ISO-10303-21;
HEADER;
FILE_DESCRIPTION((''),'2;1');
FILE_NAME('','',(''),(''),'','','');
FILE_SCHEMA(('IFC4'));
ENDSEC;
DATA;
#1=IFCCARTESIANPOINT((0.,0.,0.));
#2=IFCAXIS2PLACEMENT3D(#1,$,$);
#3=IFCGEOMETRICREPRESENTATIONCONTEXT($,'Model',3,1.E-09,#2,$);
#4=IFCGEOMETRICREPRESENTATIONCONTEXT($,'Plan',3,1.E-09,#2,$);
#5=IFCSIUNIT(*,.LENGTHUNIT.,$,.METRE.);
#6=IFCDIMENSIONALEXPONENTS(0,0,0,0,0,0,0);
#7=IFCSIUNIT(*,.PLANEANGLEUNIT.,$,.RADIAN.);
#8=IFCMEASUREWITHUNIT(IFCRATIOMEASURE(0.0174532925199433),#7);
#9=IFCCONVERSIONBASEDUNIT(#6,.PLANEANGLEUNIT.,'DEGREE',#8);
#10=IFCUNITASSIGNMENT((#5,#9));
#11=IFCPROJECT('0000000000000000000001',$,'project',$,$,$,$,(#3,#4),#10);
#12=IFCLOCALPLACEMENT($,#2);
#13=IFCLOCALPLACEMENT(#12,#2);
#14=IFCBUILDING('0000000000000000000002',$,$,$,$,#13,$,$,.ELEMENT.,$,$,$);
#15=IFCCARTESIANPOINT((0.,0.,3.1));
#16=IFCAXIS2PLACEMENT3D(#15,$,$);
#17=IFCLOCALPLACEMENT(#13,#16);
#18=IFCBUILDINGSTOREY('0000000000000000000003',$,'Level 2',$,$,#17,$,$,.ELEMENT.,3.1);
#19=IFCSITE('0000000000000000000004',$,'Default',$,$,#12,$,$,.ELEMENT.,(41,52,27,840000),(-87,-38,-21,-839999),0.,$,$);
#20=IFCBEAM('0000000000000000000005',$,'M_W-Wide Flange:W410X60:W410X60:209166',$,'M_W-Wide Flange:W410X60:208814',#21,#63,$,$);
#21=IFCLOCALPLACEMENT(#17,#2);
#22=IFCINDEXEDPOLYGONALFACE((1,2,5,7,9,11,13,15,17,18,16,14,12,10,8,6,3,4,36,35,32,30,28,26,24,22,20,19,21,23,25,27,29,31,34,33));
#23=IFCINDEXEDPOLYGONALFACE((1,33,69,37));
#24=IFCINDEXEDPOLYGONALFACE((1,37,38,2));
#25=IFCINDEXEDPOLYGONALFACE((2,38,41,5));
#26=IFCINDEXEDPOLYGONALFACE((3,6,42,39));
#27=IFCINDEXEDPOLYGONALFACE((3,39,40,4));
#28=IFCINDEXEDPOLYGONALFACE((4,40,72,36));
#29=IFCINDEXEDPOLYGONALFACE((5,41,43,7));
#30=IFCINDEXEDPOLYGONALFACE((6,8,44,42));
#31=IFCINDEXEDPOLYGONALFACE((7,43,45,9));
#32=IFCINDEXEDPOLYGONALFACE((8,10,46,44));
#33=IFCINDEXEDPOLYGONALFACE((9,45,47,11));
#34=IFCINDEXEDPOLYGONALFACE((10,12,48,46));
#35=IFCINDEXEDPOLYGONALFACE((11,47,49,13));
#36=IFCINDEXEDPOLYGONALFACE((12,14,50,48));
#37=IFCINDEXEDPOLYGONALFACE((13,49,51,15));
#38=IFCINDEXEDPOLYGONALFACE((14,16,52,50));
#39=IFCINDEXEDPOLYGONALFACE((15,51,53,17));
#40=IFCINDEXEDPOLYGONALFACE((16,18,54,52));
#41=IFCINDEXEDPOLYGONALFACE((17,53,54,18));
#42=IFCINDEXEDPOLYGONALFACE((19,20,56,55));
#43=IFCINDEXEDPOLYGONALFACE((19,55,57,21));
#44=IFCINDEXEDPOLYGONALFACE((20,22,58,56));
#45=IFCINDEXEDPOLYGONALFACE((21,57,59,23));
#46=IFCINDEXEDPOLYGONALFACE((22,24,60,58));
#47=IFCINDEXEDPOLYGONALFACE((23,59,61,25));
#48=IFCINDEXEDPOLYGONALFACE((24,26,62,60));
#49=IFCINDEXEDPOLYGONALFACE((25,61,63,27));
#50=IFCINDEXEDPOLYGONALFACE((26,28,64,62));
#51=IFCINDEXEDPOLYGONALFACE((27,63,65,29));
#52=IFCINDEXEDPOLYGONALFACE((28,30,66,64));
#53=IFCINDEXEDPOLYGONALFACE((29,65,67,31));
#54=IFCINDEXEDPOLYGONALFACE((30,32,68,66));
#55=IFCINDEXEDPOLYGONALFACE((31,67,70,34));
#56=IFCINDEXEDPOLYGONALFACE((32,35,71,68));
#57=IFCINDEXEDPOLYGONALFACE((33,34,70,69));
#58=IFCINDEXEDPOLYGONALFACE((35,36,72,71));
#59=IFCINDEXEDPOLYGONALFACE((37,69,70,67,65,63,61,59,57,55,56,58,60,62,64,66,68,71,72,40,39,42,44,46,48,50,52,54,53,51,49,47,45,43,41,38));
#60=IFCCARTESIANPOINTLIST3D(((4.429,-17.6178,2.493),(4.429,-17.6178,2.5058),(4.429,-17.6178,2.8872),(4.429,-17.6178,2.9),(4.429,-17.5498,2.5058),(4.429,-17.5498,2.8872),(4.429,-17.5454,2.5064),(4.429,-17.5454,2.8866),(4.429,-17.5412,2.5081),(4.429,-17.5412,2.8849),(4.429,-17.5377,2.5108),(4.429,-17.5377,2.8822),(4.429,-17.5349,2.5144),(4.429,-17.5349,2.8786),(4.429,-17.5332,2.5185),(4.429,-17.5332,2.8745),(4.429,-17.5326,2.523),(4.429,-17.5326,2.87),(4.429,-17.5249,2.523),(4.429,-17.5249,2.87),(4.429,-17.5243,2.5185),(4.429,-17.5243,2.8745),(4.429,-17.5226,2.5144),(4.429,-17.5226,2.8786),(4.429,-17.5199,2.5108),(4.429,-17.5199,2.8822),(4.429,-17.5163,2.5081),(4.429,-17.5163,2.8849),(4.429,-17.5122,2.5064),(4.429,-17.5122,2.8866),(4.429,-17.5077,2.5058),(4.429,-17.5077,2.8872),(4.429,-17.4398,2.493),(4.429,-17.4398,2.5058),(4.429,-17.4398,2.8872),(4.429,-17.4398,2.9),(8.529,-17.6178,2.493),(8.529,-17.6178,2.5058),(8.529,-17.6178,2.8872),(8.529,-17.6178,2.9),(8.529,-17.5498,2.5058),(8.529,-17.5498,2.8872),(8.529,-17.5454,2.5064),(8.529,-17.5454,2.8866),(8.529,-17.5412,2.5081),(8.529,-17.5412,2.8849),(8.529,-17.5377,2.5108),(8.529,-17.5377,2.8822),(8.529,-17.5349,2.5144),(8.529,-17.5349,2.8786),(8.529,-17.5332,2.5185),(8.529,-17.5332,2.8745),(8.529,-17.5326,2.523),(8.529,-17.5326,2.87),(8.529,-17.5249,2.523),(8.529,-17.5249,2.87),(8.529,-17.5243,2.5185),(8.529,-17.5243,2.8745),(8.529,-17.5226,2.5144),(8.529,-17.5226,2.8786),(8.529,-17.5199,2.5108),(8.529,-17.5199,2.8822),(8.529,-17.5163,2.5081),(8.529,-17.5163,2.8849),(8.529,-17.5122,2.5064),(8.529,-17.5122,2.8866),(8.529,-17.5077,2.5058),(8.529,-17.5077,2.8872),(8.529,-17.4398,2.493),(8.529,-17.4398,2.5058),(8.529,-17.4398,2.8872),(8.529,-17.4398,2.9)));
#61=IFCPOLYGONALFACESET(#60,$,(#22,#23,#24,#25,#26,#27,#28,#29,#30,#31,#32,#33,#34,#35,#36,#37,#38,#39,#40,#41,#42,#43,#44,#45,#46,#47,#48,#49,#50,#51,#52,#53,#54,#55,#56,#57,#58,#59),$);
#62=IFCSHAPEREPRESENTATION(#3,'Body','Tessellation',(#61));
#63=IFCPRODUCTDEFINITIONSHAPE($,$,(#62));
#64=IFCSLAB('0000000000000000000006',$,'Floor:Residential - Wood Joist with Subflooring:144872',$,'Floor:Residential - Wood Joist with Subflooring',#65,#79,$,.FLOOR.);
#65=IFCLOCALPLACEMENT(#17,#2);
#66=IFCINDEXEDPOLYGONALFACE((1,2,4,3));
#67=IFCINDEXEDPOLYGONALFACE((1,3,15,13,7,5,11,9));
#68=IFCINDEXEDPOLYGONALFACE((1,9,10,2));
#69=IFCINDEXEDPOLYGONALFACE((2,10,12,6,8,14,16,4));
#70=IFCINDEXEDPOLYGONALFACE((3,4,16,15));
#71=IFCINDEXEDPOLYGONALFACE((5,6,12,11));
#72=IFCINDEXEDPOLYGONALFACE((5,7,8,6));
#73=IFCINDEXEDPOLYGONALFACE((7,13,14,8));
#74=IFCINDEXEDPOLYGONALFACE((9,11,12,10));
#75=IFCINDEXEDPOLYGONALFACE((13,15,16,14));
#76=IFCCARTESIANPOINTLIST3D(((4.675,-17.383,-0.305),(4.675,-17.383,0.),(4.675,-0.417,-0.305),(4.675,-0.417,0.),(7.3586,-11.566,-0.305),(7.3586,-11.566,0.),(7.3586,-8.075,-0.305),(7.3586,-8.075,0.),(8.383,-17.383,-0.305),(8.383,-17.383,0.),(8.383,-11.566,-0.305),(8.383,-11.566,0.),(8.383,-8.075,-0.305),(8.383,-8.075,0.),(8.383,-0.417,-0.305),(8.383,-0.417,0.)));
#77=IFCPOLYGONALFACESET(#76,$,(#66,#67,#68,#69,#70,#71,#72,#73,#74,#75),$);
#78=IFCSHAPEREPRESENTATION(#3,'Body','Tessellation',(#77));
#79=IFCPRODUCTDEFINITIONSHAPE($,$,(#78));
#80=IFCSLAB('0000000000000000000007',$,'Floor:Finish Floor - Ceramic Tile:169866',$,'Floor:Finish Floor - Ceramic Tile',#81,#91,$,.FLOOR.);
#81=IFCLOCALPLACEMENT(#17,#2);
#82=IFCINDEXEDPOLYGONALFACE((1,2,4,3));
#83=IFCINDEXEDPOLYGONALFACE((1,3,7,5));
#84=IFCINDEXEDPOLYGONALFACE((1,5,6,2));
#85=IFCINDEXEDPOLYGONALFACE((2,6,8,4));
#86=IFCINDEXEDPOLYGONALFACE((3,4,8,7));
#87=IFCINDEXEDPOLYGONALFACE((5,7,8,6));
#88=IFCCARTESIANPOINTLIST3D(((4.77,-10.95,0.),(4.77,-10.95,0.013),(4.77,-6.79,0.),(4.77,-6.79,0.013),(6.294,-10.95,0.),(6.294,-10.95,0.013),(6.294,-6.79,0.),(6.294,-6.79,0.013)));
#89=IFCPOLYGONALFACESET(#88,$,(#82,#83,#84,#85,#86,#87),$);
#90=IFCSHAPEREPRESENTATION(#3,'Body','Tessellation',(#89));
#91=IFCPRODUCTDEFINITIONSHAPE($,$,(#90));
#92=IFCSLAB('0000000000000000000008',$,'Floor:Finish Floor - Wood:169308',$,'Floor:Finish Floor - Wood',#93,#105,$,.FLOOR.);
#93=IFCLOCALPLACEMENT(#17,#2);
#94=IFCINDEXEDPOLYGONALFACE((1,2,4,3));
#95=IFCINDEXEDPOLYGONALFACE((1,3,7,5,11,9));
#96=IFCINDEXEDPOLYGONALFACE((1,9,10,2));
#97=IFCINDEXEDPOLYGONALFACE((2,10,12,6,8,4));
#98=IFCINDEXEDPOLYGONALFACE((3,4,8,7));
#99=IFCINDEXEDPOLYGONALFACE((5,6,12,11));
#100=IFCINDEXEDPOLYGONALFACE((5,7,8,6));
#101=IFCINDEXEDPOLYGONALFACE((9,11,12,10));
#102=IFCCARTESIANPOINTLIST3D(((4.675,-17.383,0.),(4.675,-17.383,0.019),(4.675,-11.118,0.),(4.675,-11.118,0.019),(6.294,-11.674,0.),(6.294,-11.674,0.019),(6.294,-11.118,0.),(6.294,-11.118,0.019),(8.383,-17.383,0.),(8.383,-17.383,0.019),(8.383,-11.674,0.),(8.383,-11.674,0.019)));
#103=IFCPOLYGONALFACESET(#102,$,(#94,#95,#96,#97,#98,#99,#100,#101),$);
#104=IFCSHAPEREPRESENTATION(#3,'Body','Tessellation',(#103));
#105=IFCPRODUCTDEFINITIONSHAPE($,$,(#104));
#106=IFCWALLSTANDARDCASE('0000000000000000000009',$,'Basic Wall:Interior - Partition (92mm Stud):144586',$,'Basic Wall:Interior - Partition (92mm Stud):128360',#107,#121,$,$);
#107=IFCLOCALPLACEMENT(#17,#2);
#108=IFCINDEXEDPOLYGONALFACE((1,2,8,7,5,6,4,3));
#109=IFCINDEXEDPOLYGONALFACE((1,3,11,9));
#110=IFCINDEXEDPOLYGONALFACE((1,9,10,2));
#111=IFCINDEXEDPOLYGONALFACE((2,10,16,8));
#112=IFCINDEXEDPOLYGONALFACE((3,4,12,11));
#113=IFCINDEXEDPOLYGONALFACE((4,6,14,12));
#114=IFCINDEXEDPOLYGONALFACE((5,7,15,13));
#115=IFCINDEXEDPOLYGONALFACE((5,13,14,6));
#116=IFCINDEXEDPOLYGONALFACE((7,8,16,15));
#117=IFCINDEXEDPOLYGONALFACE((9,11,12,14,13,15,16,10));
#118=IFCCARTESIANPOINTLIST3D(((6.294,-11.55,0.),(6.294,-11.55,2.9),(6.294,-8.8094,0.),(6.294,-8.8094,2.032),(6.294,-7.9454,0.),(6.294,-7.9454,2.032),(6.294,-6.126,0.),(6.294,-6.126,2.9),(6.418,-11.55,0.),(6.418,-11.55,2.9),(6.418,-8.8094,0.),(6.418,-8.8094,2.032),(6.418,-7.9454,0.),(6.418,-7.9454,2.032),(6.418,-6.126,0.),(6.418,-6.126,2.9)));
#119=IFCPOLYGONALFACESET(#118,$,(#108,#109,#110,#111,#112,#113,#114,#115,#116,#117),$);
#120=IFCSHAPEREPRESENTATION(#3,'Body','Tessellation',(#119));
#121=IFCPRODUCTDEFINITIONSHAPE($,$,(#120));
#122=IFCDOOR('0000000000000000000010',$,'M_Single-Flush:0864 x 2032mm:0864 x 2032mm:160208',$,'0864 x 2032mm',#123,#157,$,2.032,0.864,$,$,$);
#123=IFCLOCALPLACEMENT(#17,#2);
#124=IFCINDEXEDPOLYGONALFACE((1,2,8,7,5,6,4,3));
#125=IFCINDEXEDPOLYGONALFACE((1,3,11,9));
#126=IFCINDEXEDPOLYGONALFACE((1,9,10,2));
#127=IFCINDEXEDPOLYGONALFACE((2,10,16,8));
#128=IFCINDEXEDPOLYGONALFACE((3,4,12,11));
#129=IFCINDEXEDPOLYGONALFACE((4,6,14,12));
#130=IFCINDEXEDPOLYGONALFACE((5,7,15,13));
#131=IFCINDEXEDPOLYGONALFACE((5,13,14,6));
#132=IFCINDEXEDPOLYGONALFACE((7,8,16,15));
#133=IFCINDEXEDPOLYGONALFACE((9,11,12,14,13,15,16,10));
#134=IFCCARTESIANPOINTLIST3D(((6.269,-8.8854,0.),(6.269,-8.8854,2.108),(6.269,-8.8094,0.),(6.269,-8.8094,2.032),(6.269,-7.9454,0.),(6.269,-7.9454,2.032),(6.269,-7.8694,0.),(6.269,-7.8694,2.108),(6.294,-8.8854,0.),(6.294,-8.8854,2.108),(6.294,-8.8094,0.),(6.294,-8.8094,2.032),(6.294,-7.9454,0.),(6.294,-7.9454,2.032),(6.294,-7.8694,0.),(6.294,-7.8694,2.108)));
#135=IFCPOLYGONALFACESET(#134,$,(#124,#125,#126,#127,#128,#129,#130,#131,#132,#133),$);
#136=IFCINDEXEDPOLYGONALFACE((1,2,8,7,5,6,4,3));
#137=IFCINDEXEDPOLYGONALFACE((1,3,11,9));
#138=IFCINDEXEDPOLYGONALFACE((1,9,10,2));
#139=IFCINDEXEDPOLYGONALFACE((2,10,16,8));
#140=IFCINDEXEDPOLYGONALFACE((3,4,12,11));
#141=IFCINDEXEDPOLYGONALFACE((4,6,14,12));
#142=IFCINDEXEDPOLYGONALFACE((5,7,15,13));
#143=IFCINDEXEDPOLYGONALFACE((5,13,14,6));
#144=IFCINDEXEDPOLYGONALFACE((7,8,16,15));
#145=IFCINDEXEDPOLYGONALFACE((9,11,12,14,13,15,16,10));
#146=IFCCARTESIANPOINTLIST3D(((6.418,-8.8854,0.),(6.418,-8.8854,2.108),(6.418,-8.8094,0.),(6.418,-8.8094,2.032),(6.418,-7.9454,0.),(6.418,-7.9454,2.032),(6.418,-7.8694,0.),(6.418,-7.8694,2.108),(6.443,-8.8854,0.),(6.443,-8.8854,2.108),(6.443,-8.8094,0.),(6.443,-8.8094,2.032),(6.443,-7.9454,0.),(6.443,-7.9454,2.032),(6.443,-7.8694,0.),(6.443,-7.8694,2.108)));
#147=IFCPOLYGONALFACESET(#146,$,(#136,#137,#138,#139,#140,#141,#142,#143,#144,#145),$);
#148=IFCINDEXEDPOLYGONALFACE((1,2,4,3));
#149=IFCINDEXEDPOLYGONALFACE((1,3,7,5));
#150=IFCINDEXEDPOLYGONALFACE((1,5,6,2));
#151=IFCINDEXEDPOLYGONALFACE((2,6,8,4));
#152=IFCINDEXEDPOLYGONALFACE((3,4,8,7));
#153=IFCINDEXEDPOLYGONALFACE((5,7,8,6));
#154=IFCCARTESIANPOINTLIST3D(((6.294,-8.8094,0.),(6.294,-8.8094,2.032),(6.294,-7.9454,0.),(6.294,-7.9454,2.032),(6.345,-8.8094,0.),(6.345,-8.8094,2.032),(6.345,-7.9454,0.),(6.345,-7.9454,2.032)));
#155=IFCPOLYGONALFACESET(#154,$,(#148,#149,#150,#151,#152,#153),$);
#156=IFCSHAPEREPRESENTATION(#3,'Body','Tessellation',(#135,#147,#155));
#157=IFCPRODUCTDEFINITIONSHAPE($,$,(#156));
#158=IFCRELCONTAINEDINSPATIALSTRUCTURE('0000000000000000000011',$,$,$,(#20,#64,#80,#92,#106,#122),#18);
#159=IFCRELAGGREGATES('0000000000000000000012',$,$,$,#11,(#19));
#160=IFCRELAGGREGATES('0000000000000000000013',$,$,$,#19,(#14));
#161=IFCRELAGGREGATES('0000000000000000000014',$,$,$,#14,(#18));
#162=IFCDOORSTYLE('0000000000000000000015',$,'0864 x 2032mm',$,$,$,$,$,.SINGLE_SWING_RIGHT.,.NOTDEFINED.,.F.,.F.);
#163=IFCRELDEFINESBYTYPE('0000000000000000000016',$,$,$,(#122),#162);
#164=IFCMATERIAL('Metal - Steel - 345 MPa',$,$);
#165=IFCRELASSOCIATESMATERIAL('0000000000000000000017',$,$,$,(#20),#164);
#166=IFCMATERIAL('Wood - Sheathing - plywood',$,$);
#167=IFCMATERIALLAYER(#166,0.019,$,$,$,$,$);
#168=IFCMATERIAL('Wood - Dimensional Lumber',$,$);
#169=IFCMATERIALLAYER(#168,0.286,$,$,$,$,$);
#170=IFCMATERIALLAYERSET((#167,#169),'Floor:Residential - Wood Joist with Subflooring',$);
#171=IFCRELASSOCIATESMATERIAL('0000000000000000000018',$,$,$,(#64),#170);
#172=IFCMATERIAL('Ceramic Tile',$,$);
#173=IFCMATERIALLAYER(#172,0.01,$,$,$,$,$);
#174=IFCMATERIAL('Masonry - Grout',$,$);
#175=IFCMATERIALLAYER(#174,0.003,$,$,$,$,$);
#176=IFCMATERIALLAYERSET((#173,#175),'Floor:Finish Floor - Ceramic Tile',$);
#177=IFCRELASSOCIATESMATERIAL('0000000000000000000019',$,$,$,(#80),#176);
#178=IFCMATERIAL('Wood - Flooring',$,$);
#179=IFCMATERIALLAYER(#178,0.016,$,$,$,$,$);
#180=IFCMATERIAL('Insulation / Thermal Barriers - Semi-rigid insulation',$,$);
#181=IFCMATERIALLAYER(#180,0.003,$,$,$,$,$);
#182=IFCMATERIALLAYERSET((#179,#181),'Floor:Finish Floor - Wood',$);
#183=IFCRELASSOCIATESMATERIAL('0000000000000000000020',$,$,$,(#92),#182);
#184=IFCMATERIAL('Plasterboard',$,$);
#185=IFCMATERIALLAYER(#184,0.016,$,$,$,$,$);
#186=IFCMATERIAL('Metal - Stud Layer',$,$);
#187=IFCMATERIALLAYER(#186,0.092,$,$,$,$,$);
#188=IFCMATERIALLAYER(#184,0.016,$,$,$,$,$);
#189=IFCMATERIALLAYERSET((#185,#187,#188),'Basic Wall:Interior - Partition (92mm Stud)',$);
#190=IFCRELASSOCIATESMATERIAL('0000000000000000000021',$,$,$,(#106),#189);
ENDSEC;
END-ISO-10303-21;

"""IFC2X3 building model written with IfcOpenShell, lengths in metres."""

from ifc_helpers import new_model, entity, si_unit, converted_unit, frame, frame_2d, origin, origin_2d_with_axis, place, context, project, spatial, polyline, circle_curve, parameter, trimmed, segment, composite_curve, rectangle, outline, extrude, source, transform, mapped, material, layer, layer_set, layer_usage, type_object, type_shapes, element, fill, save


model = new_model("IFC2X3")

# Units and contexts
model_context = context("Model", 3, precision=1e-09, world=origin())
plan_context = context("Plan", 3, precision=1e-09, world=origin())
ifc_project = project(units=[si_unit("LENGTHUNIT", "METRE"), converted_unit("PLANEANGLEUNIT", "DEGREE", entity("IfcRatioMeasure", 0.0174532925199433), si_unit("PLANEANGLEUNIT", "RADIAN"), dimensions=[0, 0, 0, 0, 0, 0, 0])], contexts=[model_context, plan_context])

# Site, building, storey
site_placement = place(None, origin())
site = spatial("IfcSite", under=ifc_project, at=site_placement, Name="Default", CompositionType="ELEMENT", RefLatitude=(41, 52, 27, 840000), RefLongitude=(-87, -38, -21, -839999), RefElevation=0.0)
building_placement = place(site_placement, origin())
building = spatial("IfcBuilding", under=site, at=building_placement, CompositionType="ELEMENT")
storey_placement = place(building_placement, frame((0.0, 0.0, 3.1)))
storey = spatial("IfcBuildingStorey", under=building, at=storey_placement, Name="Level 2", CompositionType="ELEMENT", Elevation=3.1)

# Beam
ifc_material_1 = material(Name="Metal - Steel - 345 MPa")
beam_placement = place(storey_placement, frame((4.429, -17.5288, 2.9), z_axis=(0.0, 0.0, 1.0), x_axis=(0.0, -1.0, 0.0)))
element("IfcBeam", 1, at=beam_placement, inside=storey, material=ifc_material_1, Name="M_W-Wide Flange:W410X60:W410X60:209166", ObjectType="M_W-Wide Flange:W410X60:208814", context=model_context, shape_type="SweptSolid", body=[
    extrude(outline(composite_curve([segment(polyline([(-0.089, -0.1907), (-0.089, -0.2035)]), True, "CONTINUOUS"), segment(polyline([(-0.089, -0.2035), (0.089, -0.2035)]), True, "CONTINUOUS"), segment(polyline([(0.089, -0.2035), (0.089, -0.1907)]), True, "CONTINUOUS"), segment(polyline([(0.089, -0.1907), (0.021, -0.1907)]), True, "CONTINUOUS"), segment(trimmed(circle_curve(frame_2d((0.021, -0.1735), x_axis=(0.0, -1.0)), 0.0172), [parameter(270.0)], [parameter(360.0)], True, "PARAMETER"), False, "CONTINUOUS"), segment(polyline([(0.0038, -0.1735), (0.0038, 0.1735)]), True, "CONTINUOUS"), segment(trimmed(circle_curve(frame_2d((0.021, 0.1735), x_axis=(-1.0, 0.0)), 0.0172), [parameter(270.0)], [parameter(360.0)], True, "PARAMETER"), False, "CONTINUOUS"), segment(polyline([(0.021, 0.1907), (0.089, 0.1907)]), True, "CONTINUOUS"), segment(polyline([(0.089, 0.1907), (0.089, 0.2035)]), True, "CONTINUOUS"), segment(polyline([(0.089, 0.2035), (-0.089, 0.2035)]), True, "CONTINUOUS"), segment(polyline([(-0.089, 0.2035), (-0.089, 0.1907)]), True, "CONTINUOUS"), segment(polyline([(-0.089, 0.1907), (-0.0211, 0.1907)]), True, "CONTINUOUS"), segment(trimmed(circle_curve(frame_2d((-0.0211, 0.1735), x_axis=(0.0, 1.0)), 0.0172), [parameter(270.0)], [parameter(0.0)], True, "PARAMETER"), False, "CONTINUOUS"), segment(polyline([(-0.0039, 0.1735), (-0.0039, -0.1735)]), True, "CONTINUOUS"), segment(trimmed(circle_curve(frame_2d((-0.0211, -0.1735), x_axis=(1.0, 0.0)), 0.0172), [parameter(270.0)], [parameter(0.0)], True, "PARAMETER"), False, "CONTINUOUS"), segment(polyline([(-0.0211, -0.1907), (-0.089, -0.1907)]), True, "CONTINUOUS")], self_intersect=False)), frame((0.0, 0.0, -0.2035), z_axis=(0.0, -1.0, 0.0), x_axis=(1.0, 0.0, 0.0)), (0.0, 0.0, -1.0), 4.1),
])

# Slabs
ifc_material_2 = material(Name="Wood - Sheathing - plywood")
ifc_layer_1 = layer(ifc_material_2, 0.019)
ifc_material_3 = material(Name="Wood - Dimensional Lumber")
ifc_layer_2 = layer(ifc_material_3, 0.286)
ifc_layer_set_1 = layer_set([ifc_layer_1, ifc_layer_2], Name="Floor:Residential - Wood Joist with Subflooring")
ifc_layer_usage_1 = layer_usage(ifc_layer_set_1, "AXIS3", "POSITIVE", 0.0)
slab_1_placement = place(storey_placement, frame((4.675, -17.383, -0.305)))
element("IfcSlab", 2, at=slab_1_placement, inside=storey, material=ifc_layer_usage_1, Name="Floor:Residential - Wood Joist with Subflooring:144872", ObjectType="Floor:Residential - Wood Joist with Subflooring", PredefinedType="FLOOR", context=model_context, shape_type="SweptSolid", body=[
    extrude(outline(polyline([(-1.854, 8.483), (-1.854, 0.825), (-0.8296, 0.825), (-0.8296, -2.666), (-1.854, -2.666), (-1.854, -8.483), (1.854, -8.483), (1.854, 8.483), (-1.854, 8.483)])), frame((1.854, 8.483, 0.305), z_axis=(0.0, 0.0, -1.0), x_axis=(-1.0, 0.0, 0.0)), (0.0, 0.0, 1.0), 0.305),
])
ifc_material_4 = material(Name="Ceramic Tile")
ifc_layer_3 = layer(ifc_material_4, 0.01)
ifc_material_5 = material(Name="Masonry - Grout")
ifc_layer_4 = layer(ifc_material_5, 0.003)
ifc_layer_set_2 = layer_set([ifc_layer_3, ifc_layer_4], Name="Floor:Finish Floor - Ceramic Tile")
ifc_layer_usage_2 = layer_usage(ifc_layer_set_2, "AXIS3", "POSITIVE", 0.0)
slab_2_placement = place(storey_placement, frame((4.77, -10.95, 0.0)))
element("IfcSlab", 3, at=slab_2_placement, inside=storey, material=ifc_layer_usage_2, Name="Floor:Finish Floor - Ceramic Tile:169866", ObjectType="Floor:Finish Floor - Ceramic Tile", PredefinedType="FLOOR", context=model_context, shape_type="SweptSolid", body=[
    extrude(rectangle(XDim=4.16, YDim=1.524, at=frame_2d((0.0, 0.0), x_axis=(0.0, -1.0))), frame((0.762, 2.08, 0.013), z_axis=(0.0, 0.0, -1.0), x_axis=(-1.0, 0.0, 0.0)), (0.0, 0.0, 1.0), 0.013),
])
ifc_material_6 = material(Name="Wood - Flooring")
ifc_layer_5 = layer(ifc_material_6, 0.016)
ifc_material_7 = material(Name="Insulation / Thermal Barriers - Semi-rigid insulation")
ifc_layer_6 = layer(ifc_material_7, 0.003)
ifc_layer_set_3 = layer_set([ifc_layer_5, ifc_layer_6], Name="Floor:Finish Floor - Wood")
ifc_layer_usage_3 = layer_usage(ifc_layer_set_3, "AXIS3", "POSITIVE", 0.0)
slab_3_placement = place(storey_placement, frame((4.675, -17.383, 0.0)))
element("IfcSlab", 4, at=slab_3_placement, inside=storey, material=ifc_layer_usage_3, Name="Floor:Finish Floor - Wood:169308", ObjectType="Floor:Finish Floor - Wood", PredefinedType="FLOOR", context=model_context, shape_type="SweptSolid", body=[
    extrude(outline(polyline([(-1.854, 2.5765), (-1.854, -3.1325), (1.854, -3.1325), (1.854, 3.1325), (0.235, 3.1325), (0.235, 2.5765), (-1.854, 2.5765)])), frame((1.854, 3.1325, 0.019), z_axis=(0.0, 0.0, -1.0), x_axis=(-1.0, 0.0, 0.0)), (0.0, 0.0, 1.0), 0.019),
])

# Wall, opening, door
ifc_material_8 = material(Name="Plasterboard")
ifc_layer_7 = layer(ifc_material_8, 0.016)
ifc_material_9 = material(Name="Metal - Stud Layer")
ifc_layer_8 = layer(ifc_material_9, 0.092)
ifc_layer_9 = layer(ifc_material_8, 0.016)
ifc_layer_set_4 = layer_set([ifc_layer_7, ifc_layer_8, ifc_layer_9], Name="Basic Wall:Interior - Partition (92mm Stud)")
ifc_layer_usage_4 = layer_usage(ifc_layer_set_4, "AXIS2", "NEGATIVE", 0.062)
wall_1_placement = place(storey_placement, frame((6.356, -11.55, 0.0), z_axis=(0.0, 0.0, 1.0), x_axis=(0.0, 1.0, 0.0)))
wall_1 = element("IfcWallStandardCase", 5, at=wall_1_placement, inside=storey, material=ifc_layer_usage_4, Name="Basic Wall:Interior - Partition (92mm Stud):144586", ObjectType="Basic Wall:Interior - Partition (92mm Stud):128360", context=model_context, shape_type="SweptSolid", body=[
    extrude(rectangle(XDim=5.424, YDim=0.124, at=frame_2d((2.712, 0.0), x_axis=(-1.0, 0.0))), origin(), (0.0, 0.0, 1.0), 2.9),
])
opening_1_placement = place(wall_1_placement, frame((2.7406, -0.062, 0.0)))
opening_1 = element("IfcOpeningElement", 6, at=opening_1_placement, cuts=wall_1, ObjectType="Opening", context=model_context, shape_type="SweptSolid", body=[
    extrude(rectangle(XDim=0.864, YDim=2.032, at=frame_2d((1.016, 0.432), x_axis=(0.0, 1.0))), frame((0.0, 0.0, 0.0), z_axis=(0.0, 1.0, 0.0), x_axis=(0.0, 0.0, 1.0)), (0.0, 0.0, 1.0), 0.124),
])
door_style = type_object("IfcDoorStyle", Name="0864 x 2032mm", ConstructionType="NOTDEFINED", OperationType="SINGLE_SWING_RIGHT", ParameterTakesPrecedence=False, Sizeable=False)
shared_shape_1 = source(origin(), model_context, "Body", "SweptSolid", [
    extrude(outline(polyline([(-0.508, -1.073), (0.508, -1.073), (0.508, 1.035), (0.432, 1.035), (0.432, -0.997), (-0.432, -0.997), (-0.432, 1.035), (-0.508, 1.035), (-0.508, -1.073)])), frame((0.432, 0.124, 1.035), z_axis=(0.0, 1.0, 0.0), x_axis=(1.0, 0.0, 0.0)), (0.0, 0.0, 1.0), 0.025),
    extrude(outline(polyline([(-1.073, -0.508), (1.035, -0.508), (1.035, -0.432), (-0.997, -0.432), (-0.997, 0.432), (1.035, 0.432), (1.035, 0.508), (-1.073, 0.508), (-1.073, -0.508)])), frame((0.432, -0.025, 1.035), z_axis=(0.0, 1.0, 0.0), x_axis=(0.0, 0.0, -1.0)), (0.0, 0.0, 1.0), 0.025),
    extrude(rectangle(XDim=0.051, YDim=0.864, at=origin_2d_with_axis()), frame((0.432, 0.0985, 0.0), z_axis=(0.0, 0.0, 1.0), x_axis=(0.0, 1.0, 0.0)), (0.0, 0.0, 1.0), 2.032),
])
type_shapes(door_style, [shared_shape_1])
door_placement = place(opening_1_placement, origin())
door = element("IfcDoor", 7, at=door_placement, inside=storey, type_object=door_style, Name="M_Single-Flush:0864 x 2032mm:0864 x 2032mm:160208", ObjectType="0864 x 2032mm", OverallHeight=2.032, OverallWidth=0.864, context=model_context, shape_type="MappedRepresentation", body=[
    mapped(shared_shape_1, transform((0.0, 0.0, 0.0), scale=1.0)),
])
fill(opening_1, door)

save(model, "model.ifc")
